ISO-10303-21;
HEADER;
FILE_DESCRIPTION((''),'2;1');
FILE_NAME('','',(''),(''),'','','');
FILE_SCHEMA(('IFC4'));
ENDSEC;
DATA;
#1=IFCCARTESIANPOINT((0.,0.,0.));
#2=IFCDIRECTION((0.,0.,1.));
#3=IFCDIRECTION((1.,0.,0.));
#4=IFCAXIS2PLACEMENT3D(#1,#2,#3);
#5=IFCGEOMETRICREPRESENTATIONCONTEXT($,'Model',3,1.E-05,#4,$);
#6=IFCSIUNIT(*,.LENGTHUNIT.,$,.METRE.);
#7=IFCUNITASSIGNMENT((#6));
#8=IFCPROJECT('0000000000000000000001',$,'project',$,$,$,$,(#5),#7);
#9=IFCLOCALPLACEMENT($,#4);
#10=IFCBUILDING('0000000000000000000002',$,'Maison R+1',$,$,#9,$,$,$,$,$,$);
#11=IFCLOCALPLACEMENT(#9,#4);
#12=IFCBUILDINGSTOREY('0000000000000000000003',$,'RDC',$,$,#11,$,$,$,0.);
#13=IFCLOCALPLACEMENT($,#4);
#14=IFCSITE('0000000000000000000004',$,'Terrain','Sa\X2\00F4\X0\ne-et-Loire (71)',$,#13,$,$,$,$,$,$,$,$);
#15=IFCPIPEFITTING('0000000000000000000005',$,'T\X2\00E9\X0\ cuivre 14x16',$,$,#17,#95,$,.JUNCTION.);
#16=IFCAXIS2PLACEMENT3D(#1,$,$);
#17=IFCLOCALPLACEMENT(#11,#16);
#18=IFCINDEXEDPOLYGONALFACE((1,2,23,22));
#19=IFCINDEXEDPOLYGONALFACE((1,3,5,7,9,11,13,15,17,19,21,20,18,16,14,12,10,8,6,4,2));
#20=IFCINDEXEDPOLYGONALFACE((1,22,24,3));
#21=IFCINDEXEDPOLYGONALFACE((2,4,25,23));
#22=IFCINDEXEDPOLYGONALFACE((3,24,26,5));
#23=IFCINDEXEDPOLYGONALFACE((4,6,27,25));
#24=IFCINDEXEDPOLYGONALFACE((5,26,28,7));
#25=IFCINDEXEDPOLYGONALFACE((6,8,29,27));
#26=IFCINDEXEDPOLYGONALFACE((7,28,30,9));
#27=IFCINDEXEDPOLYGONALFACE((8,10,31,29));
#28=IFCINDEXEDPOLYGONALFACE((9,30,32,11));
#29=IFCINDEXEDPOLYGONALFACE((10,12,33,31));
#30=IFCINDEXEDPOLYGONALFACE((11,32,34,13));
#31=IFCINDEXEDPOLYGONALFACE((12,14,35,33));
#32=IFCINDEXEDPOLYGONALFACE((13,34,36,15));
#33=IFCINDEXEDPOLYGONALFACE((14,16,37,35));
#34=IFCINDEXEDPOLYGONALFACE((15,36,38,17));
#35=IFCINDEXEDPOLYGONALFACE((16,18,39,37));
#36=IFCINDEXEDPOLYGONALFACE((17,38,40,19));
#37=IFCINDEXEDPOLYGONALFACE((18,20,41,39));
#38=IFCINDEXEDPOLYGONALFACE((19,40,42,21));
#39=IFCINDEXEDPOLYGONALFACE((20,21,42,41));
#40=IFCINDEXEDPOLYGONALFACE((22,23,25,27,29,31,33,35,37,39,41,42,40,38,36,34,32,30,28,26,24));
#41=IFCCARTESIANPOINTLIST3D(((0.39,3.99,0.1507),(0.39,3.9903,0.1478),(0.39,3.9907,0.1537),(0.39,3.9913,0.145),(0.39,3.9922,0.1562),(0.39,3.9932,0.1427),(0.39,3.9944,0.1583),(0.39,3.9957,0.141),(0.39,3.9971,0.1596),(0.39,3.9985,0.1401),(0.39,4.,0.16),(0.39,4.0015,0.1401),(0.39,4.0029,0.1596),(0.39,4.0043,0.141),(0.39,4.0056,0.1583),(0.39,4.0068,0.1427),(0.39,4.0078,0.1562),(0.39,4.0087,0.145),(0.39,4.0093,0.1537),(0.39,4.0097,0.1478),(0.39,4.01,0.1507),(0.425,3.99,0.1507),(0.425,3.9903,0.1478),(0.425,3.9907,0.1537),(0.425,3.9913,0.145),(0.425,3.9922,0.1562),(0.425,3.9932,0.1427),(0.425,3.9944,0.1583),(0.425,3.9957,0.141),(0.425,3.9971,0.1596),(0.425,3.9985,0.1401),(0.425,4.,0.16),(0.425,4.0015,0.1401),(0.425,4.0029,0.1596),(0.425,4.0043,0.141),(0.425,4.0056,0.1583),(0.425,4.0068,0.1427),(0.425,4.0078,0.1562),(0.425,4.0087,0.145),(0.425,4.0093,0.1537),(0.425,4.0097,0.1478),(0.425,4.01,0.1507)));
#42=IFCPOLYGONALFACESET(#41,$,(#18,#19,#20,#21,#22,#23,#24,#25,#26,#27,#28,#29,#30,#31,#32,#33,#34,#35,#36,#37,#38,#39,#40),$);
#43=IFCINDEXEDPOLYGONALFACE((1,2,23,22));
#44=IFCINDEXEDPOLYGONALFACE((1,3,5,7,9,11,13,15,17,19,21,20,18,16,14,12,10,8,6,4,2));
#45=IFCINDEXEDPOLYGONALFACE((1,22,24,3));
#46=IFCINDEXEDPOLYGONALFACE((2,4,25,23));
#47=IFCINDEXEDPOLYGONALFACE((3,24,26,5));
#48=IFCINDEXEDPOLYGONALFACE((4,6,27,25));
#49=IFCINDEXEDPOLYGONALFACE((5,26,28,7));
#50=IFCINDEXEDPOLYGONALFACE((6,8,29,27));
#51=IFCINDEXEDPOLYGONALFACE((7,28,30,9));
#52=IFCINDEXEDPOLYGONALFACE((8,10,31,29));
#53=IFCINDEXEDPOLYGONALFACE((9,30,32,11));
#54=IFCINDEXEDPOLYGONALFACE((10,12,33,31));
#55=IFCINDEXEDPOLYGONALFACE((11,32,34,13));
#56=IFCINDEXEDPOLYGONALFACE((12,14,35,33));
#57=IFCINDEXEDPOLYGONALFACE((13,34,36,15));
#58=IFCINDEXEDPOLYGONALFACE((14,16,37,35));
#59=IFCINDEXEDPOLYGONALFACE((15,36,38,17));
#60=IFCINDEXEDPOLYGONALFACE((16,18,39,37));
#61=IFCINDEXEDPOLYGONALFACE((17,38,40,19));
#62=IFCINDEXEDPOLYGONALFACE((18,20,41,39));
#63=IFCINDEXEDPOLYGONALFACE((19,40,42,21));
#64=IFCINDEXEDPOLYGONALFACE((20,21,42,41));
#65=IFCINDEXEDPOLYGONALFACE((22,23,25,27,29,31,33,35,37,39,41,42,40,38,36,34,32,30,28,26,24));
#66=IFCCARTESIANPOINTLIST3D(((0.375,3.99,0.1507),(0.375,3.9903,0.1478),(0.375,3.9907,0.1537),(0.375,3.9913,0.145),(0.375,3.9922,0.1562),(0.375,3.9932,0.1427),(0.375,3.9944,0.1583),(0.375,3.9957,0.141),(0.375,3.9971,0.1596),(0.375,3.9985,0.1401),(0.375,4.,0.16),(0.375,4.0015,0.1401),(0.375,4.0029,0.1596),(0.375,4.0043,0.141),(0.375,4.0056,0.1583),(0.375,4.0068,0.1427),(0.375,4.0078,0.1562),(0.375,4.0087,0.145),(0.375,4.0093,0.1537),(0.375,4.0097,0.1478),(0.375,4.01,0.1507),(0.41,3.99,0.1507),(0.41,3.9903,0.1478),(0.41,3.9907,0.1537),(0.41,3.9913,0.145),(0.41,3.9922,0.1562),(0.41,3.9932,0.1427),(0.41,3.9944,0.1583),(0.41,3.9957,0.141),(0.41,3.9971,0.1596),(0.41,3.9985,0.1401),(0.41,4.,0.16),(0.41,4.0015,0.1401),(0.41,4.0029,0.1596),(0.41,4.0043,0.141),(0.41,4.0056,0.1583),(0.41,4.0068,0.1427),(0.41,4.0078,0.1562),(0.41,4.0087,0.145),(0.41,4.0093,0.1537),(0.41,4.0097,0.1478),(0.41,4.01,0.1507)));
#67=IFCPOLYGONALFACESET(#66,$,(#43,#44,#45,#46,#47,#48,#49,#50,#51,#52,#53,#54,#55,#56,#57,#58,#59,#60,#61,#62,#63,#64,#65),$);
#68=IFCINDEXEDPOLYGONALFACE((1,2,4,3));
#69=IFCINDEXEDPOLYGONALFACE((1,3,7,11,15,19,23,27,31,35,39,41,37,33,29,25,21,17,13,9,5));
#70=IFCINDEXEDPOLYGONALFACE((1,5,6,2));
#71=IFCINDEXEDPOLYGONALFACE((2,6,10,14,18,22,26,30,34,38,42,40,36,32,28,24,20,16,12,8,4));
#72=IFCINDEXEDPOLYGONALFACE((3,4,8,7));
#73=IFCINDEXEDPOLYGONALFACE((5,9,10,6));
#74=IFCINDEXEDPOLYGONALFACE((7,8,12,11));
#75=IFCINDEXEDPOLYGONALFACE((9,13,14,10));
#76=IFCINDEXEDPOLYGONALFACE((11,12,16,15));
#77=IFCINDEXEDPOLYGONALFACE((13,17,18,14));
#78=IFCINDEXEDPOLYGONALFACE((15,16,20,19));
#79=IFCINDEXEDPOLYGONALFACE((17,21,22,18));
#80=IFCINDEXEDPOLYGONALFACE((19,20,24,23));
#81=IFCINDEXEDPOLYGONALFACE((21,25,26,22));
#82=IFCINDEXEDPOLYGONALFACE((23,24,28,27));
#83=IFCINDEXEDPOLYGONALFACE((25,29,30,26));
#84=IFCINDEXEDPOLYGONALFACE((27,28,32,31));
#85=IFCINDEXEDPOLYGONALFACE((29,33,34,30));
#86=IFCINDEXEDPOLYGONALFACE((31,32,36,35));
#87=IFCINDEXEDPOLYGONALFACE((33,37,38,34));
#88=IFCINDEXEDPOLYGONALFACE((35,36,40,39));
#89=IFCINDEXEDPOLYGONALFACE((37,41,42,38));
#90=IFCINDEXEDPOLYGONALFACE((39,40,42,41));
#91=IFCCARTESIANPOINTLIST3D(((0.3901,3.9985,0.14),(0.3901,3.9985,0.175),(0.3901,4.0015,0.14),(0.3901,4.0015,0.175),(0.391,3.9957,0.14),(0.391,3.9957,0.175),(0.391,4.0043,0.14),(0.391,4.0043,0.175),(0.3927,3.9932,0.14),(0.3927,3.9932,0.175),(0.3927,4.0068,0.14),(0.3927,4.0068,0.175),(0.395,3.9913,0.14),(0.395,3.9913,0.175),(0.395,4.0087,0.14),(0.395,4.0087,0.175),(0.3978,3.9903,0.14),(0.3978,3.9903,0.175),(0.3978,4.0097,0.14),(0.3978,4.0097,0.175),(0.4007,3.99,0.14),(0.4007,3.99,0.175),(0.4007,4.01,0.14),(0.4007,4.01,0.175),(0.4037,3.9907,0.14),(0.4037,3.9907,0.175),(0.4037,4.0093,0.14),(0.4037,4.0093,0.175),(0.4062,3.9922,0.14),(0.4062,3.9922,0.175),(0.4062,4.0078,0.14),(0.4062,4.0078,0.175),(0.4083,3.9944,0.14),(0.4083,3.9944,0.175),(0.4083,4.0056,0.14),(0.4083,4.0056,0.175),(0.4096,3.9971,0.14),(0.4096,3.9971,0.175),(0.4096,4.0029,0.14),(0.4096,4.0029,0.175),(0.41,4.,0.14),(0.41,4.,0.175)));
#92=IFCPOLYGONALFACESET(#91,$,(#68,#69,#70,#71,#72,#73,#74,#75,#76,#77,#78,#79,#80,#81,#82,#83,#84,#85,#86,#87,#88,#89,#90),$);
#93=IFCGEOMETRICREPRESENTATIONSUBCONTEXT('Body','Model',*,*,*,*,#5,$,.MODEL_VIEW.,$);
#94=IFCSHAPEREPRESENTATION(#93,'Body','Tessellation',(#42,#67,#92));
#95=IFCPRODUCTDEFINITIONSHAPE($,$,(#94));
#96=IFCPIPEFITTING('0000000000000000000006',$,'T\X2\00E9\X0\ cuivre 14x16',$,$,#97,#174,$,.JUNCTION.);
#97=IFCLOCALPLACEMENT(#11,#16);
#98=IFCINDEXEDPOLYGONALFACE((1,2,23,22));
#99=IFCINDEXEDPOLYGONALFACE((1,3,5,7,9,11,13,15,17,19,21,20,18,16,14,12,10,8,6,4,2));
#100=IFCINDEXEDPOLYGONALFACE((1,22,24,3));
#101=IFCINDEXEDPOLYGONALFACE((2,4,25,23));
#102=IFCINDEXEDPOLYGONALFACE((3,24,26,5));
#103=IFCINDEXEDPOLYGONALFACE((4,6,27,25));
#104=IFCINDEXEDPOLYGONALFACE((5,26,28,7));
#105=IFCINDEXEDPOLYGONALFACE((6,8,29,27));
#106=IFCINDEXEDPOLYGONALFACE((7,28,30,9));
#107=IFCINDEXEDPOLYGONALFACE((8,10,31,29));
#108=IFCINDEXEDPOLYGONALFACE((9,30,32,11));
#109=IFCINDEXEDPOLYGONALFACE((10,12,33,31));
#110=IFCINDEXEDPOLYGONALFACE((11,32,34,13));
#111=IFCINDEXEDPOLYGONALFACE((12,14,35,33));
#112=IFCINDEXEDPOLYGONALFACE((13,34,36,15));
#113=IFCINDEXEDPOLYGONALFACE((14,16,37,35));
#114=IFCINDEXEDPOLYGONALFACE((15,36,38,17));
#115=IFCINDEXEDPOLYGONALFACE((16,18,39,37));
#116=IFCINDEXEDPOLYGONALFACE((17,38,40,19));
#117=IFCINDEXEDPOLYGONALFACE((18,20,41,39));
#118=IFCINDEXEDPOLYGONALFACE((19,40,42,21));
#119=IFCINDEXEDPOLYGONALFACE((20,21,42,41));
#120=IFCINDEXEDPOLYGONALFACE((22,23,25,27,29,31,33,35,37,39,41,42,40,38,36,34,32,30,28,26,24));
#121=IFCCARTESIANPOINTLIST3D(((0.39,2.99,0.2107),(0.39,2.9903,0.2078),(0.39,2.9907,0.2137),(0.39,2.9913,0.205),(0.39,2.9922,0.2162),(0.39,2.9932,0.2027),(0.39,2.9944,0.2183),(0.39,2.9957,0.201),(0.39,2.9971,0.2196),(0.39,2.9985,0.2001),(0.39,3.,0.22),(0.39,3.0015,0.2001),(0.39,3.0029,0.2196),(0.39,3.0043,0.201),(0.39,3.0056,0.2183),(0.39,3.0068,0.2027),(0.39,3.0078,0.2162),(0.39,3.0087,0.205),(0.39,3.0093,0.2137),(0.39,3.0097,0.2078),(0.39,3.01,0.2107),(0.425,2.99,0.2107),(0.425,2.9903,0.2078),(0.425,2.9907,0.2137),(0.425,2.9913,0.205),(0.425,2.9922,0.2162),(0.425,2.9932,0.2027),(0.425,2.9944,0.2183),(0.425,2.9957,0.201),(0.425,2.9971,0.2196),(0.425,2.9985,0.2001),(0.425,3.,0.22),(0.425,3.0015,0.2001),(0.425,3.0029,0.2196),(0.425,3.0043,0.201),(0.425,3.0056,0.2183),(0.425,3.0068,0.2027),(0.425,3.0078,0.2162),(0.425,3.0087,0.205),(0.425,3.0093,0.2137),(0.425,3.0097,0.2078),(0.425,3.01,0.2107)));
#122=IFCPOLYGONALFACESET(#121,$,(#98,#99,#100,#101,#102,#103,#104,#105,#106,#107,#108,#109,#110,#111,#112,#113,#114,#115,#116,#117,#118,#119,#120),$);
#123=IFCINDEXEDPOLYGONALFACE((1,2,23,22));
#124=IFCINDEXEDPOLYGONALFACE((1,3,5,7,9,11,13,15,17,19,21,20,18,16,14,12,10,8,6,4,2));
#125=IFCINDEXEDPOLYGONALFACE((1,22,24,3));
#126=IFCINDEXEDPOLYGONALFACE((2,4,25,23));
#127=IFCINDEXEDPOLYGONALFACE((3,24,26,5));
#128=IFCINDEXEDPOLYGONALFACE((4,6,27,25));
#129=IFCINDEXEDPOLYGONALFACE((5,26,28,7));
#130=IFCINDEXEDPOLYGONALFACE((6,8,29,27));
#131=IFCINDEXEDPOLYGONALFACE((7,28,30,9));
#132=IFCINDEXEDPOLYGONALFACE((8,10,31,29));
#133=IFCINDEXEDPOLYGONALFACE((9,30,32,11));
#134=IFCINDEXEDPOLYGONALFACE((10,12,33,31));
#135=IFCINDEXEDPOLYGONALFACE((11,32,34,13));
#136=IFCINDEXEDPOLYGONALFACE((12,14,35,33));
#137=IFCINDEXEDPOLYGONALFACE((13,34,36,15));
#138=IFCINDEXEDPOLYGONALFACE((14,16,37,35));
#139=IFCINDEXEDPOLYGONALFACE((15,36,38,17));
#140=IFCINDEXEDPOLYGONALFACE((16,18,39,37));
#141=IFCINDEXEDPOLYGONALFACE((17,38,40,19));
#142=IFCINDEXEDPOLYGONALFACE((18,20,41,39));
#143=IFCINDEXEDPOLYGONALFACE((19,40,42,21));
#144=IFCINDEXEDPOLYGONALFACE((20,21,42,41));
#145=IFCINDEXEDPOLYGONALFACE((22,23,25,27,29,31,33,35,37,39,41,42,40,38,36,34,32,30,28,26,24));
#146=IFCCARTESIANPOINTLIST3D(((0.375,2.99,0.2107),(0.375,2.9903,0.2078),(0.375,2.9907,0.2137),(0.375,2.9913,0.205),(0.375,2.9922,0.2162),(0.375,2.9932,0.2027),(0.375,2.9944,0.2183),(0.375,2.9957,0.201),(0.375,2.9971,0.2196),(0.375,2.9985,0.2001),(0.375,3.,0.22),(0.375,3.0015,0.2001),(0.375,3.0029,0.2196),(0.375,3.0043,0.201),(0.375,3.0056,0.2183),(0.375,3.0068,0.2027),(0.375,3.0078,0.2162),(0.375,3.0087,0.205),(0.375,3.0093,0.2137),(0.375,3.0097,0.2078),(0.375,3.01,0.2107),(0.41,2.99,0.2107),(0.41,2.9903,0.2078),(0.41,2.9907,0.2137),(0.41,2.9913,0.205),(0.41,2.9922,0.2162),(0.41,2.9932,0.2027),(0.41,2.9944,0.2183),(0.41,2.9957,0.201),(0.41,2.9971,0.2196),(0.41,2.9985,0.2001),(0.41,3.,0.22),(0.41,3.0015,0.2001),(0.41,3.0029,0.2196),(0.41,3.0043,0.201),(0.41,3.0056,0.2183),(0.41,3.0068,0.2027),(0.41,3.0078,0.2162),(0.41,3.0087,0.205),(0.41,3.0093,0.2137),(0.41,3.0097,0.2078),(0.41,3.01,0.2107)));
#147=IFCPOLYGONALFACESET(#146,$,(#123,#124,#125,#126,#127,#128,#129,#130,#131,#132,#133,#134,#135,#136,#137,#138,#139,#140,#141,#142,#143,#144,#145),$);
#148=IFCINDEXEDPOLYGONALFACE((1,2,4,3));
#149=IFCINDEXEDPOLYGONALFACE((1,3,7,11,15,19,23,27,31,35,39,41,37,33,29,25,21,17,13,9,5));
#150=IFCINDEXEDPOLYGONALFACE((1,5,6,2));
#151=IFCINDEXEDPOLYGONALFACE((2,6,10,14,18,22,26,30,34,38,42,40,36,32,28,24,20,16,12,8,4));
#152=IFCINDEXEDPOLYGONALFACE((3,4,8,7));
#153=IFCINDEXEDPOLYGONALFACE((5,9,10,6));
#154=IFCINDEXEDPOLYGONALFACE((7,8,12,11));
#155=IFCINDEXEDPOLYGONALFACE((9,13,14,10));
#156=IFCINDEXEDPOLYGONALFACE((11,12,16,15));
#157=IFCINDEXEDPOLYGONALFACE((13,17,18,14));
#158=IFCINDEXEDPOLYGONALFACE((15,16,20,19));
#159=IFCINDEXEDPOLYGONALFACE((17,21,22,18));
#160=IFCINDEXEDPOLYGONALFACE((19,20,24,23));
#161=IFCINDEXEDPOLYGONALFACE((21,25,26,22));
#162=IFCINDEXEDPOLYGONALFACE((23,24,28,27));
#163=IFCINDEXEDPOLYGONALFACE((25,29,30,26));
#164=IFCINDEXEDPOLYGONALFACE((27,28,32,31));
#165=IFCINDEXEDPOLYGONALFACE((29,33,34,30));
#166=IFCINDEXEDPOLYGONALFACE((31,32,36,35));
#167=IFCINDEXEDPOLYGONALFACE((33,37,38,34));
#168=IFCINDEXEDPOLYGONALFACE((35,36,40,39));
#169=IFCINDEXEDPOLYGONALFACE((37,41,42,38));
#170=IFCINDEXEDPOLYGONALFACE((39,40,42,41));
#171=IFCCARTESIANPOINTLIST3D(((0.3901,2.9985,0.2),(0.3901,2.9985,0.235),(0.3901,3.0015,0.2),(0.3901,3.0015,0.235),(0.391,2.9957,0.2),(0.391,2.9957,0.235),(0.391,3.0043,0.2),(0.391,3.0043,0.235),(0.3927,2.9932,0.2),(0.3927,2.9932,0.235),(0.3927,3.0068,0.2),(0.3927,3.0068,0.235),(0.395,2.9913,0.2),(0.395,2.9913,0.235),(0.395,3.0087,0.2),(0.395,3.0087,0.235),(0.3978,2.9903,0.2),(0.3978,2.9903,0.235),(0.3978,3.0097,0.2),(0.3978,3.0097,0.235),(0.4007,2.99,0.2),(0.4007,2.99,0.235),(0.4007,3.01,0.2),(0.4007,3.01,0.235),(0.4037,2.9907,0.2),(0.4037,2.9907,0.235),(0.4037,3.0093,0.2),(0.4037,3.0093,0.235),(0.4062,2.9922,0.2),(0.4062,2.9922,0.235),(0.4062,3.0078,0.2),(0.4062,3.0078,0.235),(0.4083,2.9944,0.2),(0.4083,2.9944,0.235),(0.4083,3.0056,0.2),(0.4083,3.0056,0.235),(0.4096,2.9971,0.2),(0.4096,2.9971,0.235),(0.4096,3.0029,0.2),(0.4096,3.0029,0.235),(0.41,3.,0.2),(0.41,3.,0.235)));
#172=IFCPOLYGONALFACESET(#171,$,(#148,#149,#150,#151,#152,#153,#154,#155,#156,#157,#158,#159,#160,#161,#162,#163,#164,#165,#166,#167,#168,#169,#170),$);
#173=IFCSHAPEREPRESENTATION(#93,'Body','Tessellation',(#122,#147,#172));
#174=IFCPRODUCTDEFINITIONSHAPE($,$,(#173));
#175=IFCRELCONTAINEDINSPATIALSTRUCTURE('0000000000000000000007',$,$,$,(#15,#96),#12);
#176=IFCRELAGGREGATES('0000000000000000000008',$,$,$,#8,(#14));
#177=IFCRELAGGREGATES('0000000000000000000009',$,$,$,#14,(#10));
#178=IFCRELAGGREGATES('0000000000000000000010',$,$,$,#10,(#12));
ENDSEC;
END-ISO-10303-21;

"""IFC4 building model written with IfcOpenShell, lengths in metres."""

from ifc_helpers import new_model, si_unit, frame, origin_with_axes, place, context, subcontext, project, spatial, circle, extrude, element, save


model = new_model("IFC4")

# Units and contexts
model_context = context("Model", 3, precision=1e-05, world=origin_with_axes())
body_context = subcontext(model_context, "Body", "Model", "MODEL_VIEW")
ifc_project = project(units=[si_unit("LENGTHUNIT", "METRE")], contexts=[model_context])

# Site, building, storey
site_placement = place(None, origin_with_axes())
site = spatial("IfcSite", under=ifc_project, at=site_placement, Name="Terrain", Description="Saône-et-Loire (71)")
building_placement = place(None, origin_with_axes())
building = spatial("IfcBuilding", under=site, at=building_placement, Name="Maison R+1")
storey_placement = place(building_placement, origin_with_axes())
storey = spatial("IfcBuildingStorey", under=building, at=storey_placement, Name="RDC", Elevation=0.0)

# Pipe fittings
for number, where, z_axis, x_axis, name in (
    (1, (0.4, 4.0, 0.15), (0.0, 0.0, 1.0), (1.0, 0.0, 0.0), "Té cuivre 14x16"),
    (2, (0.4, 3.0, 0.21), (0.0, 0.0, 1.0), (1.0, 0.0, 0.0), "Té cuivre 14x16"),
):
    element("IfcPipeFitting", number, at=place(storey_placement, frame(where, z_axis=z_axis, x_axis=x_axis)), inside=storey, Name=name, PredefinedType="JUNCTION", context=body_context, shape_type="SweptSolid", body=[
        extrude(circle(Radius=0.01), frame((-0.01, 0.0, 0.0), z_axis=(1.0, 0.0, 0.0), x_axis=(0.0, 0.0, 1.0)), (0.0, 0.0, 1.0), 0.035),
        extrude(circle(Radius=0.01), frame((0.01, 0.0, 0.0), z_axis=(-1.0, 0.0, 0.0), x_axis=(0.0, 0.0, 1.0)), (0.0, 0.0, 1.0), 0.035),
        extrude(circle(Radius=0.01), frame((0.0, 0.0, -0.01), z_axis=(0.0, 0.0, 1.0), x_axis=(1.0, 0.0, 0.0)), (0.0, 0.0, 1.0), 0.035),
    ])

save(model, "model.ifc")
